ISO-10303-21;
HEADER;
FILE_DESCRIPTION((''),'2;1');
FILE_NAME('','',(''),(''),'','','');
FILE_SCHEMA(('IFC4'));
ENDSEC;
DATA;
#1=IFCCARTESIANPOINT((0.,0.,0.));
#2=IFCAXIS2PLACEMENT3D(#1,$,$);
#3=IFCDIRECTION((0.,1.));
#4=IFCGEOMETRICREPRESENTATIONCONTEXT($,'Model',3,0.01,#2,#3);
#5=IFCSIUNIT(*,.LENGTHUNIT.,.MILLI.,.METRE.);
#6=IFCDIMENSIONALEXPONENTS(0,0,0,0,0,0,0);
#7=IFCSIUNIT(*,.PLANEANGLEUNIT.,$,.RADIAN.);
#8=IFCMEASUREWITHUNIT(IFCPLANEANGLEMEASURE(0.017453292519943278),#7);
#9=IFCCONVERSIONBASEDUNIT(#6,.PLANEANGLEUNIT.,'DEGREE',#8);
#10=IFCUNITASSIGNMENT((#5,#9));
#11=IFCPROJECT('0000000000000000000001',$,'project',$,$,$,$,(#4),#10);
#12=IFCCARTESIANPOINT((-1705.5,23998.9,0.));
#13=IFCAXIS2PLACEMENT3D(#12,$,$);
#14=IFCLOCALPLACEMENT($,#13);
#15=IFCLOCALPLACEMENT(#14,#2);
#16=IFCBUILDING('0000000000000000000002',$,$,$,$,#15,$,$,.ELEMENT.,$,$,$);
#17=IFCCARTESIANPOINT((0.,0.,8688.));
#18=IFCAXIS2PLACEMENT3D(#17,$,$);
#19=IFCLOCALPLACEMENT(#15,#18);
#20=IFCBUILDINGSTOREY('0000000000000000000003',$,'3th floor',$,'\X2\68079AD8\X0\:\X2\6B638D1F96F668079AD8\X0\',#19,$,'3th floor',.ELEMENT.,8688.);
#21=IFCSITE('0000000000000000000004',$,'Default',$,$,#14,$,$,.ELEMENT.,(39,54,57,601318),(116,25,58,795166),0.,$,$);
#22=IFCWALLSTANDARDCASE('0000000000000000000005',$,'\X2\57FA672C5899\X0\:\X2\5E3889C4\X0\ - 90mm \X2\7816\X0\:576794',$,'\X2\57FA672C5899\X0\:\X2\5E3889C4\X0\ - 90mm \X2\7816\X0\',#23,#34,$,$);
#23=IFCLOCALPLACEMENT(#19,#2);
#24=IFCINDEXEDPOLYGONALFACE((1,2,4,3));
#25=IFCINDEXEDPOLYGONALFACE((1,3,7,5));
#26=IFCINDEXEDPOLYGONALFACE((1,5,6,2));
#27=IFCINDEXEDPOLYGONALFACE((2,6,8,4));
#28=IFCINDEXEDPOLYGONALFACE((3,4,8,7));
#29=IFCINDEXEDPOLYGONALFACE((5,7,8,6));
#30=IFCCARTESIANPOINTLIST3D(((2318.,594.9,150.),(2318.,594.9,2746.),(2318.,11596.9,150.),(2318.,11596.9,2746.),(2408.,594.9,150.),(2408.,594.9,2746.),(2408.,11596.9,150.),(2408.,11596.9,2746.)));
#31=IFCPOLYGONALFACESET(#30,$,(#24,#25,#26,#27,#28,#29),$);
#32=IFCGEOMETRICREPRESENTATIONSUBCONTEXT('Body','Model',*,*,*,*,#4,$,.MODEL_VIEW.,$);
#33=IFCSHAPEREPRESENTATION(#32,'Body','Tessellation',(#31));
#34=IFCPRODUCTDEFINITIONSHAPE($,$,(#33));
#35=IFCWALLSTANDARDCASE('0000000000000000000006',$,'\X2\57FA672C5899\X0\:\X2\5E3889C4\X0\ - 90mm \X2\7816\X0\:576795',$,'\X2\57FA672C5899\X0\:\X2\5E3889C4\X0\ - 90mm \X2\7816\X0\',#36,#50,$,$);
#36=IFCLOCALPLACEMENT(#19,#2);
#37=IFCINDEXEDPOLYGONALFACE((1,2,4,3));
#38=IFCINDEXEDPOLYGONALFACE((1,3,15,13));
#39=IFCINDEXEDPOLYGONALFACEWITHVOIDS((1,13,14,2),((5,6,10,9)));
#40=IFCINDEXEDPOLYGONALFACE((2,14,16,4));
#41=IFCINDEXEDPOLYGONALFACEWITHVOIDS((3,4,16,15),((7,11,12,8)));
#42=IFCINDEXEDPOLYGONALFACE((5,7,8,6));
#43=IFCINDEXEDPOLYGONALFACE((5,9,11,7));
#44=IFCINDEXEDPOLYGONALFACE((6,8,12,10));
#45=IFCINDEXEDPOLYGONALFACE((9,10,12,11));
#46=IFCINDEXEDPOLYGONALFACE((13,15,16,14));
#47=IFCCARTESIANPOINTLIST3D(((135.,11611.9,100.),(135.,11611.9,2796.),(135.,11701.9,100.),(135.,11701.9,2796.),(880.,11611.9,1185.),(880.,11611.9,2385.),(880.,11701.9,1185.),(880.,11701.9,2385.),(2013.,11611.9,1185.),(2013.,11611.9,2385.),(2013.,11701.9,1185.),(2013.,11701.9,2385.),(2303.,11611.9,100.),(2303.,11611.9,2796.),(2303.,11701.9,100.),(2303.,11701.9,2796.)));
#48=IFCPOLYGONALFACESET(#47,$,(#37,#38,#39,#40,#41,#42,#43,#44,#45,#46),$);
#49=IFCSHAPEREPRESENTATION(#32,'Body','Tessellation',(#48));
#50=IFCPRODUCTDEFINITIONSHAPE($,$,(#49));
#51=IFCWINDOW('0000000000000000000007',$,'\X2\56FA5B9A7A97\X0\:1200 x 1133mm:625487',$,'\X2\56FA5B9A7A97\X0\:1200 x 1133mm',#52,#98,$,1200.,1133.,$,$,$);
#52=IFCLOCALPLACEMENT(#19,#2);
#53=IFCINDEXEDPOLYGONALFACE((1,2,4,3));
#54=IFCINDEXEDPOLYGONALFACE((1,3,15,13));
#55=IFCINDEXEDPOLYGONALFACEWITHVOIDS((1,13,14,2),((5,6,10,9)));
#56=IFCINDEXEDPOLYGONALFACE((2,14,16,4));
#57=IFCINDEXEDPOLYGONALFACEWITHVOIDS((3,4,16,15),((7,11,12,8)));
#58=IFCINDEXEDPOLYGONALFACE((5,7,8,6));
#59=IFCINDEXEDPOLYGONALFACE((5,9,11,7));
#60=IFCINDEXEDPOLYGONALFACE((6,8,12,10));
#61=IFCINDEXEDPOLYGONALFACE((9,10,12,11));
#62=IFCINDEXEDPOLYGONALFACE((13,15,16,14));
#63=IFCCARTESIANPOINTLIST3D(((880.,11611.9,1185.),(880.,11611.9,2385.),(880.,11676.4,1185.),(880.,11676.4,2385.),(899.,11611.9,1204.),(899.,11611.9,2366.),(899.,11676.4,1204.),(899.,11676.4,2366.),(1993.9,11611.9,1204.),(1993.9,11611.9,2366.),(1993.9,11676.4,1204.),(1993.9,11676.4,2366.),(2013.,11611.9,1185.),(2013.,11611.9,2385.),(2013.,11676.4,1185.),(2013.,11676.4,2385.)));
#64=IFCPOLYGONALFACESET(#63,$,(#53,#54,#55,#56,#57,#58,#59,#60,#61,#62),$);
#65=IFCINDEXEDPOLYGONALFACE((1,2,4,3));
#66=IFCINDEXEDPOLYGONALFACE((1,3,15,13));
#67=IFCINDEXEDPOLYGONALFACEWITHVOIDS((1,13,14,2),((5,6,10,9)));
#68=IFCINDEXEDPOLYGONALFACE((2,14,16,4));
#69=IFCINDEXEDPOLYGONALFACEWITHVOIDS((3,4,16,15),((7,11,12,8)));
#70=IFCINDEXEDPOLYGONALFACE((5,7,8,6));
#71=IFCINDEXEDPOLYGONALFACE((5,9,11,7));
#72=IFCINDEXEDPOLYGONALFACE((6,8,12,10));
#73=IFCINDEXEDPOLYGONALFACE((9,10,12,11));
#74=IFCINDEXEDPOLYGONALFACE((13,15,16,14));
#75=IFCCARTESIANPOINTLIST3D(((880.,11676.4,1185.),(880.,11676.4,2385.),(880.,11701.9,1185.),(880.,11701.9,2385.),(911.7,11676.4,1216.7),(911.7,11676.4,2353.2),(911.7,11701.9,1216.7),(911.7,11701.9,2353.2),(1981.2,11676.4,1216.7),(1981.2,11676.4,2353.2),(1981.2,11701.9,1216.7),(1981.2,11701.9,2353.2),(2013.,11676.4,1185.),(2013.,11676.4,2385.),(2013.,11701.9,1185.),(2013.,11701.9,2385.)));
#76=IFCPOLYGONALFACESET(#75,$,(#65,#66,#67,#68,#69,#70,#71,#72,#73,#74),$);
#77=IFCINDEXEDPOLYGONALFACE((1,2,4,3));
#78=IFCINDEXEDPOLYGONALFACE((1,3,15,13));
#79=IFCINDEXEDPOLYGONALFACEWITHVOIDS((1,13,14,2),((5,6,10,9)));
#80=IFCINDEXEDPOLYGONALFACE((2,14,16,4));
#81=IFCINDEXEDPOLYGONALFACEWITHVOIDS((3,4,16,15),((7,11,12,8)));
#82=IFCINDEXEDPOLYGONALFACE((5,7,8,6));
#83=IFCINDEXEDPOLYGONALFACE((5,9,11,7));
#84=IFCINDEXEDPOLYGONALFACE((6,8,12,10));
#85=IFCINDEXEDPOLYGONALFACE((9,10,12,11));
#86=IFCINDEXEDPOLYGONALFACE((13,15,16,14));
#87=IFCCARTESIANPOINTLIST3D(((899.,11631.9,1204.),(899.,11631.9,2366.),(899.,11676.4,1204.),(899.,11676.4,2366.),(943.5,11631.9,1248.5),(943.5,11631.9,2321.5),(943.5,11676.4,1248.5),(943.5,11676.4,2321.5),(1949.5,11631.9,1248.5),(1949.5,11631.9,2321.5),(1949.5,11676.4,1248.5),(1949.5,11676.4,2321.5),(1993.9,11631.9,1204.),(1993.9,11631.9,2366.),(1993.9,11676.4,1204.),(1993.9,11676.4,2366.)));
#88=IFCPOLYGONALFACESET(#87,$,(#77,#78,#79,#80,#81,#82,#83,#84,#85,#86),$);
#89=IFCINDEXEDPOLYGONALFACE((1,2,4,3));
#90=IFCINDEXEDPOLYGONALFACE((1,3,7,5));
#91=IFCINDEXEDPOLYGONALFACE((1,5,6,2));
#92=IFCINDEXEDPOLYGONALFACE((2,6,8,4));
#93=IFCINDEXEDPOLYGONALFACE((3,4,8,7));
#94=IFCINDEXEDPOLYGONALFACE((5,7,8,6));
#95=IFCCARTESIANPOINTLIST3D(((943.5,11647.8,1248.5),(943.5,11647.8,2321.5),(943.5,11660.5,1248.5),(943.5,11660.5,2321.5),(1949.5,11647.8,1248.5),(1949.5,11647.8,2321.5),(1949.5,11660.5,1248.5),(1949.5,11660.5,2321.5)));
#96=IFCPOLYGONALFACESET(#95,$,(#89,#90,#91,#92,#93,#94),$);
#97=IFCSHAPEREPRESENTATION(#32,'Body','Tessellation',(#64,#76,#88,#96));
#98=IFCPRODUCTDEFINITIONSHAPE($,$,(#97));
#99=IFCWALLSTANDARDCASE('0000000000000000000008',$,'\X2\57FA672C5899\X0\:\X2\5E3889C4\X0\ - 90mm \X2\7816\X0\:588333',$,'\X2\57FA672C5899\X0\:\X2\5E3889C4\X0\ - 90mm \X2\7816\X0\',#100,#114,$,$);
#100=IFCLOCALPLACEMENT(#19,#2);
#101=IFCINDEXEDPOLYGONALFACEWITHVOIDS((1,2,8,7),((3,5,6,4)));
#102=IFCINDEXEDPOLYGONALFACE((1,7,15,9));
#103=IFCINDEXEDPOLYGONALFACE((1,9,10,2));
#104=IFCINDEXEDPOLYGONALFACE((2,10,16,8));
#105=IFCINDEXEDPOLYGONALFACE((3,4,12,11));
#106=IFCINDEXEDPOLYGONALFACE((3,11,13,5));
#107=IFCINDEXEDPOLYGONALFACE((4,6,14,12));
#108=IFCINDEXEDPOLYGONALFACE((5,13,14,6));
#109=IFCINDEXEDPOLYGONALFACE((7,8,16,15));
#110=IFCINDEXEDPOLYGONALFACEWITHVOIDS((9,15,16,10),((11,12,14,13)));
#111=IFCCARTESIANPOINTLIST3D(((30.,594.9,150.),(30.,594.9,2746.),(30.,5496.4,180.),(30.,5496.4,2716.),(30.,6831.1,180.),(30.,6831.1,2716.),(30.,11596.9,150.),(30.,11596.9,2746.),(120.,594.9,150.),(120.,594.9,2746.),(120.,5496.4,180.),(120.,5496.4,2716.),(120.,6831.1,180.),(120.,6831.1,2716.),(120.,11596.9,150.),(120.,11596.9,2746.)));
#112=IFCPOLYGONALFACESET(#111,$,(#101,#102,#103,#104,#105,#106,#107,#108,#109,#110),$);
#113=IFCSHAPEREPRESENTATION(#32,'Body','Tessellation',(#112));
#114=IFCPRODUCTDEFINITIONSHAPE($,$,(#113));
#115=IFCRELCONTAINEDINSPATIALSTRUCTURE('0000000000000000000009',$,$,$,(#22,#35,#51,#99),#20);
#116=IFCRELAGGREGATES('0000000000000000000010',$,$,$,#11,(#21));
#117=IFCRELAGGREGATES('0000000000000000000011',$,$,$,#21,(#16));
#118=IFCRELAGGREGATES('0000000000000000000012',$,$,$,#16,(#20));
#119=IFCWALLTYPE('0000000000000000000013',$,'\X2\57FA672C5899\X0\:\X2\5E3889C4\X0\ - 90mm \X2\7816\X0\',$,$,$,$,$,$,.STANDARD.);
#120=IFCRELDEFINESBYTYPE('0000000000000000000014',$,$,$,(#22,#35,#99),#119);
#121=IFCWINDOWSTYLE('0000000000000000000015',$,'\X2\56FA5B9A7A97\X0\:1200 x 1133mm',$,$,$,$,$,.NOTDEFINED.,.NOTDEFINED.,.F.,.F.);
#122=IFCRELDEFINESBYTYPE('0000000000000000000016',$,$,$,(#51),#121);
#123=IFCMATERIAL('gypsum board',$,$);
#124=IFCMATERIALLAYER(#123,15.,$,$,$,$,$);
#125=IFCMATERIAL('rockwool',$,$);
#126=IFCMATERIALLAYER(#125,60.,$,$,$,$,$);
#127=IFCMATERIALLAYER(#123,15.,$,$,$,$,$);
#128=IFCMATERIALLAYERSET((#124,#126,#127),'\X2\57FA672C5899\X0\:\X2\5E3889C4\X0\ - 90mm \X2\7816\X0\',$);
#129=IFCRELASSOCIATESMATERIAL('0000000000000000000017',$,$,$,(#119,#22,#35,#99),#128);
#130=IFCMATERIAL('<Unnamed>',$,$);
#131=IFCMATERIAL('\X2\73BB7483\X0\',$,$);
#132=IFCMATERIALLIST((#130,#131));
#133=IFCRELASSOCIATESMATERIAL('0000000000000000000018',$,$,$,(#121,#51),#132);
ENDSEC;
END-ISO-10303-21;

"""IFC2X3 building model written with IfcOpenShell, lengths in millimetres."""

from ifc_helpers import new_model, entity, si_unit, converted_unit, direction, frame, frame_2d, origin, origin_2d_with_axis, place, context, subcontext, project, spatial, polyline, rectangle, outline, extrude, source, transform, mapped, material, material_list, layer, layer_set, layer_usage, type_object, type_shapes, element, fill, save


model = new_model("IFC2X3")

# Units and contexts
model_context = context("Model", 3, precision=0.01, world=origin(), true_north=direction((0.0, 1.0)))
body_context = subcontext(model_context, "Body", "Model", "MODEL_VIEW")
ifc_project = project(units=[si_unit("LENGTHUNIT", "METRE", prefix="MILLI"), converted_unit("PLANEANGLEUNIT", "DEGREE", entity("IfcPlaneAngleMeasure", 0.017453292519943278), si_unit("PLANEANGLEUNIT", "RADIAN"), dimensions=[0, 0, 0, 0, 0, 0, 0])], contexts=[model_context])

# Site, building, storey
site_placement = place(None, frame((-1705.5, 23998.9, 0.0)))
site = spatial("IfcSite", under=ifc_project, at=site_placement, Name="Default", CompositionType="ELEMENT", RefLatitude=(39, 54, 57, 601318), RefLongitude=(116, 25, 58, 795166), RefElevation=0.0)
building_placement = place(site_placement, origin())
building = spatial("IfcBuilding", under=site, at=building_placement, CompositionType="ELEMENT")
storey_placement = place(building_placement, frame((0.0, 0.0, 8688.0)))
storey = spatial("IfcBuildingStorey", under=building, at=storey_placement, Name="3th floor", ObjectType="标高:正负零标高", LongName="3th floor", CompositionType="ELEMENT", Elevation=8688.0)

# Wall
ifc_material_1 = material(Name="gypsum board")
ifc_layer_1 = layer(ifc_material_1, 15.0)
ifc_material_2 = material(Name="rockwool")
ifc_layer_2 = layer(ifc_material_2, 60.0)
ifc_layer_3 = layer(ifc_material_1, 15.0)
ifc_layer_set = layer_set([ifc_layer_1, ifc_layer_2, ifc_layer_3], Name="基本墙:常规 - 90mm 砖")
ifc_layer_usage_1 = layer_usage(ifc_layer_set, "AXIS2", "NEGATIVE", 45.0)
wall_type = type_object("IfcWallType", Name="基本墙:常规 - 90mm 砖", PredefinedType="STANDARD", material=ifc_layer_set)
wall_1_placement = place(storey_placement, frame((2363.0, 11596.9, 150.0), z_axis=(0.0, 0.0, 1.0), x_axis=(0.0, -1.0, 0.0)))
element("IfcWallStandardCase", 1, at=wall_1_placement, inside=storey, type_object=wall_type, material=ifc_layer_usage_1, Name="基本墙:常规 - 90mm 砖:576794", ObjectType="基本墙:常规 - 90mm 砖", context=body_context, shape_type="SweptSolid", body=[
    extrude(rectangle(XDim=11002.0, YDim=90.0, at=frame_2d((5501.0, 0.0), x_axis=(-1.0, 0.0))), origin(), (0.0, 0.0, 1.0), 2596.0),
])

# Wall, opening, window
ifc_layer_usage_2 = layer_usage(ifc_layer_set, "AXIS2", "NEGATIVE", 45.0)
wall_2_placement = place(storey_placement, frame((2303.0, 11656.9, 100.0), z_axis=(0.0, 0.0, 1.0), x_axis=(-1.0, 0.0, 0.0)))
wall_2 = element("IfcWallStandardCase", 2, at=wall_2_placement, inside=storey, type_object=wall_type, material=ifc_layer_usage_2, Name="基本墙:常规 - 90mm 砖:576795", ObjectType="基本墙:常规 - 90mm 砖", context=body_context, shape_type="SweptSolid", body=[
    extrude(rectangle(XDim=2168.0, YDim=90.0, at=frame_2d((1084.0, 0.0), x_axis=(-1.0, 0.0))), origin(), (0.0, 0.0, 1.0), 2696.0),
])
opening_1_placement = place(wall_2_placement, frame((290.0, -45.0, 1085.0)))
opening_1 = element("IfcOpeningElement", 3, at=opening_1_placement, cuts=wall_2, ObjectType="Opening", context=body_context, shape_type="SweptSolid", body=[
    extrude(rectangle(XDim=1200.0, YDim=1133.0, at=frame_2d((600.0, 566.5), x_axis=(-1.0, 0.0))), frame((0.0, 0.0, 0.0), z_axis=(0.0, 1.0, 0.0), x_axis=(0.0, 0.0, 1.0)), (0.0, 0.0, 1.0), 90.0),
])
ifc_material_3 = material(Name="<Unnamed>")
ifc_material_4 = material(Name="玻璃")
ifc_material_list = material_list([ifc_material_3, ifc_material_4])
window_style = type_object("IfcWindowStyle", Name="固定窗:1200 x 1133mm", ConstructionType="NOTDEFINED", OperationType="NOTDEFINED", ParameterTakesPrecedence=False, Sizeable=False, material=ifc_material_list)
shared_shape = source(origin(), body_context, "Body", "SweptSolid", [
    extrude(outline(polyline([(-600.0, -566.5), (600.0, -566.5), (600.0, 566.5), (-600.0, 566.5), (-600.0, -566.5)]), holes=[polyline([(-580.9, -547.4), (-580.9, 547.5), (581.0, 547.5), (581.0, -547.4), (-580.9, -547.4)])]), frame((566.5, 25.5, 600.0), z_axis=(0.0, 1.0, 0.0), x_axis=(0.0, 0.0, -1.0)), (0.0, 0.0, 1.0), 64.4),
    extrude(outline(polyline([(-566.5, -600.0), (566.5, -600.0), (566.5, 600.0), (-566.5, 600.0), (-566.5, -600.0)]), holes=[polyline([(-534.8, -568.2), (-534.8, 568.3), (534.7, 568.3), (534.7, -568.2), (-534.8, -568.2)])]), frame((566.5, 0.0, 600.0), z_axis=(0.0, 1.0, 0.0), x_axis=(1.0, 0.0, 0.0)), (0.0, 0.0, 1.0), 25.5),
    extrude(outline(polyline([(-547.4, -581.0), (547.4, -581.0), (547.4, 581.0), (-547.4, 581.0), (-547.4, -581.0)]), holes=[polyline([(-503.0, -536.5), (-503.0, 536.5), (503.0, 536.5), (503.0, -536.5), (-503.0, -536.5)])]), frame((566.5, 25.5, 600.0), z_axis=(0.0, 1.0, 0.0), x_axis=(1.0, 0.0, 0.0)), (0.0, 0.0, 1.0), 44.4),
    extrude(rectangle(XDim=12.7, YDim=1006.0, at=origin_2d_with_axis()), frame((566.5, 47.8, 63.5), z_axis=(0.0, 0.0, 1.0), x_axis=(0.0, 1.0, 0.0)), (0.0, 0.0, 1.0), 1073.0),
])
type_shapes(window_style, [shared_shape])
window_placement = place(opening_1_placement, origin())
window = element("IfcWindow", 4, at=window_placement, inside=storey, type_object=window_style, material=ifc_material_list, Name="固定窗:1200 x 1133mm:625487", ObjectType="固定窗:1200 x 1133mm", OverallHeight=1200.0, OverallWidth=1133.0, context=body_context, shape_type="MappedRepresentation", body=[
    mapped(shared_shape, transform((0.0, 0.0, 0.0), scale=1.0)),
])
fill(opening_1, window)

# Wall, opening
ifc_layer_usage_3 = layer_usage(ifc_layer_set, "AXIS2", "NEGATIVE", 45.0)
wall_3_placement = place(storey_placement, frame((75.0, 11596.9, 150.0), z_axis=(0.0, 0.0, 1.0), x_axis=(0.0, -1.0, 0.0)))
wall_3 = element("IfcWallStandardCase", 5, at=wall_3_placement, inside=storey, type_object=wall_type, material=ifc_layer_usage_3, Name="基本墙:常规 - 90mm 砖:588333", ObjectType="基本墙:常规 - 90mm 砖", context=body_context, shape_type="SweptSolid", body=[
    extrude(rectangle(XDim=11002.0, YDim=90.0, at=frame_2d((5501.0, 0.0), x_axis=(-1.0, 0.0))), origin(), (0.0, 0.0, 1.0), 2596.0),
])
opening_2_placement = place(wall_3_placement, origin())
element("IfcOpeningElement", 6, at=opening_2_placement, cuts=wall_3, ObjectType="Opening", context=body_context, shape_type="SweptSolid", body=[
    extrude(rectangle(XDim=2536.0, YDim=1334.7, at=frame_2d((0.0, 0.0), x_axis=(0.0, 1.0))), frame((5433.2, 45.0, 1298.0), z_axis=(0.0, -1.0, 0.0), x_axis=(-1.0, 0.0, 0.0)), (0.0, 0.0, 1.0), 90.0),
])

save(model, "model.ifc")
